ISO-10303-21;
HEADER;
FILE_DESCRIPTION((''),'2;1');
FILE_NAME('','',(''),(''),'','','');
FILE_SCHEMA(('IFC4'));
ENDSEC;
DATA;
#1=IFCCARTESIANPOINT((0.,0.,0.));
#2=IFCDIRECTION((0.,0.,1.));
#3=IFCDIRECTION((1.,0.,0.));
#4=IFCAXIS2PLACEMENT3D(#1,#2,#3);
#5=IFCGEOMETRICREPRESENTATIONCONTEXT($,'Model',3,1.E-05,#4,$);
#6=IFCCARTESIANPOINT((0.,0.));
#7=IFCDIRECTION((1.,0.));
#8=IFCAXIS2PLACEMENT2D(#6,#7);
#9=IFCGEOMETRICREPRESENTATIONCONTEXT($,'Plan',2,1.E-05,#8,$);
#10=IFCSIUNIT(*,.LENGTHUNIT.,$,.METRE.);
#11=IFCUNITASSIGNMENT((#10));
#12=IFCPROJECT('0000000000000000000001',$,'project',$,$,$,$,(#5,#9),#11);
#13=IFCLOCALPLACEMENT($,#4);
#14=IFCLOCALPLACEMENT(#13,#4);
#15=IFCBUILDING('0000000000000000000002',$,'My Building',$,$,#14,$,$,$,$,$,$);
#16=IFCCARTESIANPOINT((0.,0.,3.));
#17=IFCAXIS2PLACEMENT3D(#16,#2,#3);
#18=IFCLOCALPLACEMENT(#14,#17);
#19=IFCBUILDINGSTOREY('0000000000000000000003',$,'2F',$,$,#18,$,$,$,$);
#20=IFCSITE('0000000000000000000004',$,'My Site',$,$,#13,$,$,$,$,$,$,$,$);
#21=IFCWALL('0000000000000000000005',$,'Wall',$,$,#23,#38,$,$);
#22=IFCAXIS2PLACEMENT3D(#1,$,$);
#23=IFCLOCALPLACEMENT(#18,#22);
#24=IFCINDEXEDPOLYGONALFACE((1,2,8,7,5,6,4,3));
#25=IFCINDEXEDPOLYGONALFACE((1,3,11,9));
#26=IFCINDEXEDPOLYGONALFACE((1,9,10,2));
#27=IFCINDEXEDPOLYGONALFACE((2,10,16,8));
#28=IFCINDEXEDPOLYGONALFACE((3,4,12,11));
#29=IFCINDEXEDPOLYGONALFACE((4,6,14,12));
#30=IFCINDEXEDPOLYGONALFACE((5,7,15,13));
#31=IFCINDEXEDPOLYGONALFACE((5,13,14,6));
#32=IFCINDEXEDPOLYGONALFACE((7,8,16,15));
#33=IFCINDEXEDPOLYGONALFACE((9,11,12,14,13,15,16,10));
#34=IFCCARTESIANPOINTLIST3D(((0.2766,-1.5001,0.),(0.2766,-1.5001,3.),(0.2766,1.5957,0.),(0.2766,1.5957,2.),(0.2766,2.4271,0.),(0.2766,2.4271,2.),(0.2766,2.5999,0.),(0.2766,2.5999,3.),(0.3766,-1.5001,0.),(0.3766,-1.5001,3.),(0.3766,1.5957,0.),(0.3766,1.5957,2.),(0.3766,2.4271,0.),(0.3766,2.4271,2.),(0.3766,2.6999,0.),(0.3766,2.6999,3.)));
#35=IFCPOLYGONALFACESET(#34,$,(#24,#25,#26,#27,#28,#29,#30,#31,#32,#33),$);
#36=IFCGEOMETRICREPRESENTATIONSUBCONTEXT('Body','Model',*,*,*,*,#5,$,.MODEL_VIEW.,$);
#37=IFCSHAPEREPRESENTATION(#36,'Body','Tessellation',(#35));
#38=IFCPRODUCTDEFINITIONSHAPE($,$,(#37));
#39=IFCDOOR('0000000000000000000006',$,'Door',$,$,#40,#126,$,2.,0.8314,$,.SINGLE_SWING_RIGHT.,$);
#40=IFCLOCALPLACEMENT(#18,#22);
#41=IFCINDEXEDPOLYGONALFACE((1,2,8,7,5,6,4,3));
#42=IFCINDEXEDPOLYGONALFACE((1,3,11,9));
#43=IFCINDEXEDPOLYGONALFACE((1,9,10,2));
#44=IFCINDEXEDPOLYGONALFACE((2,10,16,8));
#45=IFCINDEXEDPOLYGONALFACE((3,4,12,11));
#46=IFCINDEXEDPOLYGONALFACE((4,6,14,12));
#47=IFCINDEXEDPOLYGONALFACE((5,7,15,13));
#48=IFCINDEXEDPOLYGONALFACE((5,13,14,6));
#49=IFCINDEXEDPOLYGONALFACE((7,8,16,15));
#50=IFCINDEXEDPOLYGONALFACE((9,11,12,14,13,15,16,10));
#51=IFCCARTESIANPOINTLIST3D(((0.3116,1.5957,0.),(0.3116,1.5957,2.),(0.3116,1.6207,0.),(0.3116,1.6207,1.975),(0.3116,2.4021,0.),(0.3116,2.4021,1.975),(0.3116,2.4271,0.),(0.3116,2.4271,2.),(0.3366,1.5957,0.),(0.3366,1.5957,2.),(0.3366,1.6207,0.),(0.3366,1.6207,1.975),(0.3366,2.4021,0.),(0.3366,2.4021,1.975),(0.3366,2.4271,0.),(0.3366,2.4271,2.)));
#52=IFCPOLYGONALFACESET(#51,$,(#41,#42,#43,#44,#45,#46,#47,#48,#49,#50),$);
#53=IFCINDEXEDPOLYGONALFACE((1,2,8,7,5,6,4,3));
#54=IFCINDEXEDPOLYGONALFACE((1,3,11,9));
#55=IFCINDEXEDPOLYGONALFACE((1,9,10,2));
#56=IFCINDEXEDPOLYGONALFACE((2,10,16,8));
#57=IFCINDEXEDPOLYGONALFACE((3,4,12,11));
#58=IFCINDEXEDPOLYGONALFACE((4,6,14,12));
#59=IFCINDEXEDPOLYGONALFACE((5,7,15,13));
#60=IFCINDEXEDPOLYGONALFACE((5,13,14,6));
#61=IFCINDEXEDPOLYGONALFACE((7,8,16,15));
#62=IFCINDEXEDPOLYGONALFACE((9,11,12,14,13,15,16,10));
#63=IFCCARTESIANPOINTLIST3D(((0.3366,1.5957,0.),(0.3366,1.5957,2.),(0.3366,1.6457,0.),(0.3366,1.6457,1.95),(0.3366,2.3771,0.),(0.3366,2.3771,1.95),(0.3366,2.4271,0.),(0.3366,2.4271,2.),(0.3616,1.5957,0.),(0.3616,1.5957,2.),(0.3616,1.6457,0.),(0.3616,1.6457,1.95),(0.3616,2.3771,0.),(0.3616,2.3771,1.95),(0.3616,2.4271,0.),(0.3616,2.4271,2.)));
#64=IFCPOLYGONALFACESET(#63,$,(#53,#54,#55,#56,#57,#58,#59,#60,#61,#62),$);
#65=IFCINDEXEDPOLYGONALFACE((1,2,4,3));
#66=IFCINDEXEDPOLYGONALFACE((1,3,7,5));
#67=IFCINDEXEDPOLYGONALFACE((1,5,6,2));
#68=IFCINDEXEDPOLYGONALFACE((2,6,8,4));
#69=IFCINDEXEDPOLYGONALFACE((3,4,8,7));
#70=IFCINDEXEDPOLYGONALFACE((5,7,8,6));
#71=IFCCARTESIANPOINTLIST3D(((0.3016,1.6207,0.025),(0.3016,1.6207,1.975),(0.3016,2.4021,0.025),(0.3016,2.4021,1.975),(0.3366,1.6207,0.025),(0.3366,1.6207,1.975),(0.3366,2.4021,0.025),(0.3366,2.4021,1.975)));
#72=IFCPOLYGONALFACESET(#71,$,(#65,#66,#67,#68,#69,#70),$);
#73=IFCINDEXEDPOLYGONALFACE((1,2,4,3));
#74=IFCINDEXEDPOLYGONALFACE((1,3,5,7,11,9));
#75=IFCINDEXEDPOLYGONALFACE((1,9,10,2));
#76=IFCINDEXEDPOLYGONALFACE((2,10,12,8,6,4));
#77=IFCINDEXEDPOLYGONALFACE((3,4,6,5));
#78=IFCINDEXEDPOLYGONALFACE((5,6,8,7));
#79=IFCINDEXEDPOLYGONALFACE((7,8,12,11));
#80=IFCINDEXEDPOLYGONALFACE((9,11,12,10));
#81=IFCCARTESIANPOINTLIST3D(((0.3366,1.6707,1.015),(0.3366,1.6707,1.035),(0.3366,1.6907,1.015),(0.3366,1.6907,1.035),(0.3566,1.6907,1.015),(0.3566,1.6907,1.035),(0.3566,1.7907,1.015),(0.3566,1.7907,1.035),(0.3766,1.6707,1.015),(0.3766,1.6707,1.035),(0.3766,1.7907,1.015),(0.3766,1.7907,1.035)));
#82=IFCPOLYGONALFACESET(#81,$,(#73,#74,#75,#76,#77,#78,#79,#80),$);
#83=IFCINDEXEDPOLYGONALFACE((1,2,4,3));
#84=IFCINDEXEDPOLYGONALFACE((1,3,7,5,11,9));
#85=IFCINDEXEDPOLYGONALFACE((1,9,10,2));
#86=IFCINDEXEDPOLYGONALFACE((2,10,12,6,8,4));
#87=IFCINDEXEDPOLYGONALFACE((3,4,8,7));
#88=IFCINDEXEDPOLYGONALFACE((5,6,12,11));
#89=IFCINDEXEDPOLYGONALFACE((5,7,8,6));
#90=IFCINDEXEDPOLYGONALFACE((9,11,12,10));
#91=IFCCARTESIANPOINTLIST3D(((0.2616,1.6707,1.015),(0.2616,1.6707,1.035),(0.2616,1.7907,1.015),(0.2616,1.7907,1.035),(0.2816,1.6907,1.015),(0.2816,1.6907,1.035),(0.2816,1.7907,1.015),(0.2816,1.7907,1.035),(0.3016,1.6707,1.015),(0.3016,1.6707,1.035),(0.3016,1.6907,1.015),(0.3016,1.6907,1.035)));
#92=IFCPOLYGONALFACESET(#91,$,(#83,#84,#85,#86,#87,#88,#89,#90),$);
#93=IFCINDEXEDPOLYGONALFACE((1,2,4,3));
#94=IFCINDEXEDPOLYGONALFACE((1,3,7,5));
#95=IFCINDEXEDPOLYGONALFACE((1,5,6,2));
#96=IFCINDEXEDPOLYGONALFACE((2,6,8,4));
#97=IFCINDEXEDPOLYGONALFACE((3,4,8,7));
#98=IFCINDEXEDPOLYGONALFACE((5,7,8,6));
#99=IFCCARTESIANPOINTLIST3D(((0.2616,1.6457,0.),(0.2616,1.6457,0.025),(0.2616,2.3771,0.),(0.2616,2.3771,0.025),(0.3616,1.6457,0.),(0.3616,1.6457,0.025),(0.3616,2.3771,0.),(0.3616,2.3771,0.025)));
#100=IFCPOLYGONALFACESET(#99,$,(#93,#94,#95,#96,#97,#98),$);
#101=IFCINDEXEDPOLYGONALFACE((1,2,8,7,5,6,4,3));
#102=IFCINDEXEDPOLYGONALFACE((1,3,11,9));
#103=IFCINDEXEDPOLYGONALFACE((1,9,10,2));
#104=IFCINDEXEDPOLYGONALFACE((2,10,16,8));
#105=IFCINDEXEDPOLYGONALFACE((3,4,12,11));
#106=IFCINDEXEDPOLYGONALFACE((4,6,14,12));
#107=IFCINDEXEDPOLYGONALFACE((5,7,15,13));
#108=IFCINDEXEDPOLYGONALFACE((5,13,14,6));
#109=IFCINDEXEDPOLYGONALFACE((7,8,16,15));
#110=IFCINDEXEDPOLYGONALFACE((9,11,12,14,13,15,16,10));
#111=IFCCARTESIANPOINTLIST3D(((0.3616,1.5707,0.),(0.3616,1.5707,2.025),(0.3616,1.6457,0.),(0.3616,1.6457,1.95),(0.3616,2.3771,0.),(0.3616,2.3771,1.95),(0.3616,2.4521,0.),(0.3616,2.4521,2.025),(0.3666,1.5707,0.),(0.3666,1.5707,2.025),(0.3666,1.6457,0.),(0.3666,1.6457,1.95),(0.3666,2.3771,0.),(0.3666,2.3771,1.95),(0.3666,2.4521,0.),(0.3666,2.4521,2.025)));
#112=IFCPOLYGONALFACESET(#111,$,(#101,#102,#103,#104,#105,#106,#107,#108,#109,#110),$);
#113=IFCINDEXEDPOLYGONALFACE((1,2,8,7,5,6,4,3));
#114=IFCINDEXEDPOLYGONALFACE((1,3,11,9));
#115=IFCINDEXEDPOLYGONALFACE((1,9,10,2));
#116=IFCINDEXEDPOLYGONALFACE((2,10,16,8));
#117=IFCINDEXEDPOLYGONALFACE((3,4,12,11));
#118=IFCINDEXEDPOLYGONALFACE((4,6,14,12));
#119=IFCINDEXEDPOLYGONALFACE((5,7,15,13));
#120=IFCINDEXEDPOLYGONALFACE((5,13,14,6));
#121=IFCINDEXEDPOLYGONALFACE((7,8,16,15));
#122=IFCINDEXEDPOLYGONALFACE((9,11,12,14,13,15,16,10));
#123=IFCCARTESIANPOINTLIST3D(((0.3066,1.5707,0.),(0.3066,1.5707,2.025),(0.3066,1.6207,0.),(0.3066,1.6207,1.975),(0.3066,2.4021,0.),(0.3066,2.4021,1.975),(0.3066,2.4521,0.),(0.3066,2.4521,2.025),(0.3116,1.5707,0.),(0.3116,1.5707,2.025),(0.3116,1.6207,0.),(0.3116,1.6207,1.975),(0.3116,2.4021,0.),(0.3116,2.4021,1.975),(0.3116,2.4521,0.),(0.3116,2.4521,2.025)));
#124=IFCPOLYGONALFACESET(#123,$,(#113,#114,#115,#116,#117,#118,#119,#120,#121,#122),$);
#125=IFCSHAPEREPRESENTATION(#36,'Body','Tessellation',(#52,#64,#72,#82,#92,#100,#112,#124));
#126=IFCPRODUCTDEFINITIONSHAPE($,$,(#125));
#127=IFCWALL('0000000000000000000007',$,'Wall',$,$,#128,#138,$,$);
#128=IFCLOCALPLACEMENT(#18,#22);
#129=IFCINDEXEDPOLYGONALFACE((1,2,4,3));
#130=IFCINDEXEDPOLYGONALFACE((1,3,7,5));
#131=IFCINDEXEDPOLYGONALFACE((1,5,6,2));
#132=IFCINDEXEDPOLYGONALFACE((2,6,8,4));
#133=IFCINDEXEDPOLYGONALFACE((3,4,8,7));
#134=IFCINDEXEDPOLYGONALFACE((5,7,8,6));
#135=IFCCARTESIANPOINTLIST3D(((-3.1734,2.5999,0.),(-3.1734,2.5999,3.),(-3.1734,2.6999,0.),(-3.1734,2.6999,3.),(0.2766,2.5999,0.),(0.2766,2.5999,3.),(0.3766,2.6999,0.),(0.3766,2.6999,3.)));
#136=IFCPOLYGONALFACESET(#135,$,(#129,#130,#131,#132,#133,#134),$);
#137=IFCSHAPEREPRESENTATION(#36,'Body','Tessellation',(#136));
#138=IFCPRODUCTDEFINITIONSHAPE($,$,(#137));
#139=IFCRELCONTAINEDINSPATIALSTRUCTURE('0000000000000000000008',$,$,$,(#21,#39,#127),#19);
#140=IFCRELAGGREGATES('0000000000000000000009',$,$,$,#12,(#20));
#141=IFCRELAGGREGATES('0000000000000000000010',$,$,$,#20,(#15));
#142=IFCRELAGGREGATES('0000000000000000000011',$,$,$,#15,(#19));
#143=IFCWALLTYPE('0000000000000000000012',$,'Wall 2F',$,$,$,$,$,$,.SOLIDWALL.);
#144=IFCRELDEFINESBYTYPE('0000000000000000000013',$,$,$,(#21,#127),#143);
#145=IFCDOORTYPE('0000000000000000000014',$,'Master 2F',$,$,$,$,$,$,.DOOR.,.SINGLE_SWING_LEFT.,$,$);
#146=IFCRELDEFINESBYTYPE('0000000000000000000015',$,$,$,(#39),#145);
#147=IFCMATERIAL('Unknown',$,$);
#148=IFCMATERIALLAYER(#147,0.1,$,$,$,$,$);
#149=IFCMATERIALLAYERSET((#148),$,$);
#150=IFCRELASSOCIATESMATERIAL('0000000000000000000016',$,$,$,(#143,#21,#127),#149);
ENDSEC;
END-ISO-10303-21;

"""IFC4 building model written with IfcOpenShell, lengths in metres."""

from ifc_helpers import new_model, entity, si_unit, frame, origin_with_axes, origin_2d_with_axis, place, context, subcontext, project, spatial, line, indexed_curve, outline, extrude, shape, source, transform, mapped, material, layer, layer_set, layer_usage, type_object, type_shapes, element, fill, save


model = new_model("IFC4")

# Units and contexts
model_context = context("Model", 3, precision=1e-05, world=origin_with_axes())
plan_context = context("Plan", 2, precision=1e-05, world=origin_2d_with_axis())
body_context_1 = subcontext(model_context, "Body", "Model", "MODEL_VIEW")
body_context_2 = subcontext(plan_context, "Body", "Plan", "PLAN_VIEW")
ifc_project = project(units=[si_unit("LENGTHUNIT", "METRE")], contexts=[model_context, plan_context])

# Site, building, storey
site_placement = place(None, origin_with_axes())
site = spatial("IfcSite", under=ifc_project, at=site_placement, Name="My Site")
building_placement = place(site_placement, origin_with_axes())
building = spatial("IfcBuilding", under=site, at=building_placement, Name="My Building")
storey_placement = place(building_placement, frame((0.0, 0.0, 3.0), z_axis=(0.0, 0.0, 1.0), x_axis=(1.0, 0.0, 0.0)))
storey = spatial("IfcBuildingStorey", under=building, at=storey_placement, Name="2F")

# Shared definitions
ifc_material = material(Name="Unknown")

# Shared definitions
ifc_layer_1 = layer(ifc_material, 0.1)
ifc_layer_set_1 = layer_set([ifc_layer_1])
wall_type = type_object("IfcWallType", Name="Wall 2F", PredefinedType="SOLIDWALL", material=ifc_layer_set_1)

# Wall, opening, door
ifc_layer_usage_1 = layer_usage(ifc_layer_set_1, "AXIS2", "POSITIVE", 0.0)
wall_1_placement = place(storey_placement, frame((0.3766, -1.6001, 0.0), z_axis=(0.0, 0.0, 1.0), x_axis=(0.0, 1.0, 0.0)))
wall_1 = element("IfcWall", 1, at=wall_1_placement, inside=storey, type_object=wall_type, material=ifc_layer_usage_1, Name="Wall", context=body_context_1, shape_type="SweptSolid", body=[
    extrude(outline(indexed_curve([(0.1, 0.0), (0.1, 0.1), (4.2, 0.1), (4.3, 0.0)], segments=[line(1, 2, 3, 4, 1)])), origin_with_axes(), (0.0, 0.0, 1.0), 3.0),
])
shared_shape_1 = source(origin_with_axes(), body_context_1, "Body", "SweptSolid", [
    extrude(outline(indexed_curve([(0.0, 0.0), (0.8314, 0.0), (0.8314, 2.0), (0.0, 2.0)], segments=[line(1, 2, 3, 4, 1)])), frame((0.0, -0.6, 0.0), z_axis=(0.0, -1.0, 0.0), x_axis=(1.0, 0.0, 0.0)), (0.0, 0.0, -1.0), 1.2),
])
opening_1_placement = place(wall_1_placement, frame((3.1958, 0.015, 0.0), z_axis=(0.0, 0.0, 1.0), x_axis=(1.0, 0.0, 0.0)))
opening_1 = element("IfcOpeningElement", 2, at=opening_1_placement, cuts=wall_1, PredefinedType="OPENING", context=body_context_1, shape_type="MappedRepresentation", body=[
    mapped(shared_shape_1, transform((0.0, 0.0, 0.0), x_axis=(1.0, 0.0, 0.0), y_axis=(0.0, 1.0, 0.0), z_axis=(0.0, 0.0, 1.0), scale=1.0)),
])
door_type_1 = type_object("IfcDoorType", Name="Master 2F", OperationType="SINGLE_SWING_LEFT", PredefinedType="DOOR")
shared_shape_2 = source(origin_with_axes(), body_context_1, "Body", "SweptSolid", [
    extrude(outline(indexed_curve([(0.0, 0.0), (0.0, 2.0), (0.8314, 2.0), (0.8314, 0.0), (0.8064, 0.0), (0.8064, 1.975), (0.025, 1.975), (0.025, 0.0)], segments=[line(1, 2, 3, 4, 5, 6, 7, 8, 1)])), frame((0.0, 0.025, 0.0), z_axis=(0.0, -1.0, 0.0), x_axis=(1.0, 0.0, 0.0)), (0.0, 0.0, -1.0), 0.025),
    extrude(outline(indexed_curve([(0.0, 0.0), (0.0, 2.0), (0.8314, 2.0), (0.8314, 0.0), (0.7814, 0.0), (0.7814, 1.95), (0.05, 1.95), (0.05, 0.0)], segments=[line(1, 2, 3, 4, 5, 6, 7, 8, 1)])), frame((0.0, 0.0, 0.0), z_axis=(0.0, -1.0, 0.0), x_axis=(1.0, 0.0, 0.0)), (0.0, 0.0, -1.0), 0.025),
    extrude(outline(indexed_curve([(0.0, 0.0), (0.7814, 0.0), (0.7814, 0.035), (0.0, 0.035)], segments=[line(1, 2, 3, 4, 1)])), frame((0.025, 0.025, 0.025), z_axis=(0.0, 0.0, 1.0), x_axis=(1.0, 0.0, 0.0)), (0.0, 0.0, 1.0), 1.95),
    extrude(outline(indexed_curve([(0.0, 0.0), (0.0, -0.04), (0.12, -0.04), (0.12, -0.02), (0.02, -0.02), (0.02, 0.0)], segments=[line(1, 2, 3, 4, 5, 6, 1)])), frame((0.075, 0.025, 1.015), z_axis=(0.0, 0.0, 1.0), x_axis=(1.0, 0.0, 0.0)), (0.0, 0.0, 1.0), 0.02),
    extrude(outline(indexed_curve([(0.0, 0.0), (0.0, 0.04), (0.12, 0.04), (0.12, 0.02), (0.02, 0.02), (0.02, 0.0)], segments=[line(1, 2, 3, 4, 5, 6, 1)])), frame((0.075, 0.06, 1.015), z_axis=(0.0, 0.0, 1.0), x_axis=(1.0, 0.0, 0.0)), (0.0, 0.0, 1.0), 0.02),
    extrude(outline(indexed_curve([(0.0, 0.0), (0.7314, 0.0), (0.7314, 0.1), (0.0, 0.1)], segments=[line(1, 2, 3, 4, 1)])), frame((0.05, 0.0, 0.0), z_axis=(0.0, 0.0, 1.0), x_axis=(1.0, 0.0, 0.0)), (0.0, 0.0, 1.0), 0.025),
    extrude(outline(indexed_curve([(0.0, 0.0), (0.0, 2.025), (0.8814, 2.025), (0.8814, 0.0), (0.8064, 0.0), (0.8064, 1.95), (0.075, 1.95), (0.075, 0.0)], segments=[line(1, 2, 3, 4, 5, 6, 7, 8, 1)])), frame((-0.025, -0.005, 0.0), z_axis=(0.0, -1.0, 0.0), x_axis=(1.0, 0.0, 0.0)), (0.0, 0.0, -1.0), 0.005),
    extrude(outline(indexed_curve([(0.0, 0.0), (0.0, 2.025), (0.8814, 2.025), (0.8814, 0.0), (0.8314, 0.0), (0.8314, 1.975), (0.05, 1.975), (0.05, 0.0)], segments=[line(1, 2, 3, 4, 5, 6, 7, 8, 1)])), frame((-0.025, 0.05, 0.0), z_axis=(0.0, -1.0, 0.0), x_axis=(1.0, 0.0, 0.0)), (0.0, 0.0, -1.0), 0.005),
])
shared_shape_3 = source(origin_with_axes(), body_context_2, "Body", "Curve2D", [
    entity("IfcIndexedPolyCurve", entity("IfcCartesianPointList2D", [[0.0, 0.0], [0.0, 0.05], [0.025, 0.05], [0.025, 0.025], [0.05, 0.025], [0.05, 0.0]]), [entity("IfcLineIndex", [1, 2, 3, 4, 5, 6, 1])]),
    entity("IfcIndexedPolyCurve", entity("IfcCartesianPointList2D", [[0.8314, 0.0], [0.8314, 0.05], [0.8064, 0.05], [0.8064, 0.025], [0.7814, 0.025], [0.7814, 0.0]]), [entity("IfcLineIndex", [1, 2, 3, 4, 5, 6, 1])]),
    entity("IfcTrimmedCurve", entity("IfcEllipse", entity("IfcAxis2Placement2D", entity("IfcCartesianPoint", [0.7714, 0.05]), entity("IfcDirection", [1.0, 0.0])), 0.7464, 0.7814), [entity("IfcCartesianPoint", [0.7714, 0.8314])], [entity("IfcCartesianPoint", [0.025, 0.05])], True, "CARTESIAN"),
    entity("IfcIndexedPolyCurve", entity("IfcCartesianPointList2D", [[0.8064, 0.05], [0.7714, 0.05], [0.7714, 0.8314], [0.8064, 0.8314]]), [entity("IfcLineIndex", [1, 2, 3, 4, 1])]),
])
type_shapes(door_type_1, [shared_shape_2, shared_shape_3])
door_1_placement = place(opening_1_placement, frame((0.0, 0.0, 0.0), z_axis=(0.0, 0.0, 1.0), x_axis=(1.0, 0.0, 0.0)))
door_1 = element("IfcDoor", 3, at=door_1_placement, inside=storey, type_object=door_type_1, Name="Door", OperationType="SINGLE_SWING_RIGHT", OverallHeight=2.0, OverallWidth=0.8314, shapes=[
    shape(body_context_1, "Body", "MappedRepresentation", [mapped(shared_shape_2, transform((0.0, 0.0, 0.0), x_axis=(1.0, 0.0, 0.0), y_axis=(0.0, 1.0, 0.0), z_axis=(0.0, 0.0, 1.0), scale=1.0))]),
    shape(body_context_2, "Body", "MappedRepresentation", [mapped(shared_shape_3, transform((0.0, 0.0, 0.0), x_axis=(1.0, 0.0, 0.0), y_axis=(0.0, 1.0, 0.0), z_axis=(0.0, 0.0, 1.0), scale=1.0))]),
])
fill(opening_1, door_1)

# Wall
ifc_layer_usage_2 = layer_usage(ifc_layer_set_1, "AXIS2", "POSITIVE", 0.0)
wall_2_placement = place(storey_placement, frame((0.3766, 2.6999, 0.0), z_axis=(0.0, 0.0, 1.0), x_axis=(-1.0, 0.0, 0.0)))
element("IfcWall", 4, at=wall_2_placement, inside=storey, type_object=wall_type, material=ifc_layer_usage_2, Name="Wall", context=body_context_1, shape_type="SweptSolid", body=[
    extrude(outline(indexed_curve([(0.0, 0.0), (0.1, 0.1), (3.55, 0.1), (3.55, 0.0)], segments=[line(1, 2, 3, 4, 1)])), origin_with_axes(), (0.0, 0.0, 1.0), 3.0),
])

save(model, "model.ifc")
